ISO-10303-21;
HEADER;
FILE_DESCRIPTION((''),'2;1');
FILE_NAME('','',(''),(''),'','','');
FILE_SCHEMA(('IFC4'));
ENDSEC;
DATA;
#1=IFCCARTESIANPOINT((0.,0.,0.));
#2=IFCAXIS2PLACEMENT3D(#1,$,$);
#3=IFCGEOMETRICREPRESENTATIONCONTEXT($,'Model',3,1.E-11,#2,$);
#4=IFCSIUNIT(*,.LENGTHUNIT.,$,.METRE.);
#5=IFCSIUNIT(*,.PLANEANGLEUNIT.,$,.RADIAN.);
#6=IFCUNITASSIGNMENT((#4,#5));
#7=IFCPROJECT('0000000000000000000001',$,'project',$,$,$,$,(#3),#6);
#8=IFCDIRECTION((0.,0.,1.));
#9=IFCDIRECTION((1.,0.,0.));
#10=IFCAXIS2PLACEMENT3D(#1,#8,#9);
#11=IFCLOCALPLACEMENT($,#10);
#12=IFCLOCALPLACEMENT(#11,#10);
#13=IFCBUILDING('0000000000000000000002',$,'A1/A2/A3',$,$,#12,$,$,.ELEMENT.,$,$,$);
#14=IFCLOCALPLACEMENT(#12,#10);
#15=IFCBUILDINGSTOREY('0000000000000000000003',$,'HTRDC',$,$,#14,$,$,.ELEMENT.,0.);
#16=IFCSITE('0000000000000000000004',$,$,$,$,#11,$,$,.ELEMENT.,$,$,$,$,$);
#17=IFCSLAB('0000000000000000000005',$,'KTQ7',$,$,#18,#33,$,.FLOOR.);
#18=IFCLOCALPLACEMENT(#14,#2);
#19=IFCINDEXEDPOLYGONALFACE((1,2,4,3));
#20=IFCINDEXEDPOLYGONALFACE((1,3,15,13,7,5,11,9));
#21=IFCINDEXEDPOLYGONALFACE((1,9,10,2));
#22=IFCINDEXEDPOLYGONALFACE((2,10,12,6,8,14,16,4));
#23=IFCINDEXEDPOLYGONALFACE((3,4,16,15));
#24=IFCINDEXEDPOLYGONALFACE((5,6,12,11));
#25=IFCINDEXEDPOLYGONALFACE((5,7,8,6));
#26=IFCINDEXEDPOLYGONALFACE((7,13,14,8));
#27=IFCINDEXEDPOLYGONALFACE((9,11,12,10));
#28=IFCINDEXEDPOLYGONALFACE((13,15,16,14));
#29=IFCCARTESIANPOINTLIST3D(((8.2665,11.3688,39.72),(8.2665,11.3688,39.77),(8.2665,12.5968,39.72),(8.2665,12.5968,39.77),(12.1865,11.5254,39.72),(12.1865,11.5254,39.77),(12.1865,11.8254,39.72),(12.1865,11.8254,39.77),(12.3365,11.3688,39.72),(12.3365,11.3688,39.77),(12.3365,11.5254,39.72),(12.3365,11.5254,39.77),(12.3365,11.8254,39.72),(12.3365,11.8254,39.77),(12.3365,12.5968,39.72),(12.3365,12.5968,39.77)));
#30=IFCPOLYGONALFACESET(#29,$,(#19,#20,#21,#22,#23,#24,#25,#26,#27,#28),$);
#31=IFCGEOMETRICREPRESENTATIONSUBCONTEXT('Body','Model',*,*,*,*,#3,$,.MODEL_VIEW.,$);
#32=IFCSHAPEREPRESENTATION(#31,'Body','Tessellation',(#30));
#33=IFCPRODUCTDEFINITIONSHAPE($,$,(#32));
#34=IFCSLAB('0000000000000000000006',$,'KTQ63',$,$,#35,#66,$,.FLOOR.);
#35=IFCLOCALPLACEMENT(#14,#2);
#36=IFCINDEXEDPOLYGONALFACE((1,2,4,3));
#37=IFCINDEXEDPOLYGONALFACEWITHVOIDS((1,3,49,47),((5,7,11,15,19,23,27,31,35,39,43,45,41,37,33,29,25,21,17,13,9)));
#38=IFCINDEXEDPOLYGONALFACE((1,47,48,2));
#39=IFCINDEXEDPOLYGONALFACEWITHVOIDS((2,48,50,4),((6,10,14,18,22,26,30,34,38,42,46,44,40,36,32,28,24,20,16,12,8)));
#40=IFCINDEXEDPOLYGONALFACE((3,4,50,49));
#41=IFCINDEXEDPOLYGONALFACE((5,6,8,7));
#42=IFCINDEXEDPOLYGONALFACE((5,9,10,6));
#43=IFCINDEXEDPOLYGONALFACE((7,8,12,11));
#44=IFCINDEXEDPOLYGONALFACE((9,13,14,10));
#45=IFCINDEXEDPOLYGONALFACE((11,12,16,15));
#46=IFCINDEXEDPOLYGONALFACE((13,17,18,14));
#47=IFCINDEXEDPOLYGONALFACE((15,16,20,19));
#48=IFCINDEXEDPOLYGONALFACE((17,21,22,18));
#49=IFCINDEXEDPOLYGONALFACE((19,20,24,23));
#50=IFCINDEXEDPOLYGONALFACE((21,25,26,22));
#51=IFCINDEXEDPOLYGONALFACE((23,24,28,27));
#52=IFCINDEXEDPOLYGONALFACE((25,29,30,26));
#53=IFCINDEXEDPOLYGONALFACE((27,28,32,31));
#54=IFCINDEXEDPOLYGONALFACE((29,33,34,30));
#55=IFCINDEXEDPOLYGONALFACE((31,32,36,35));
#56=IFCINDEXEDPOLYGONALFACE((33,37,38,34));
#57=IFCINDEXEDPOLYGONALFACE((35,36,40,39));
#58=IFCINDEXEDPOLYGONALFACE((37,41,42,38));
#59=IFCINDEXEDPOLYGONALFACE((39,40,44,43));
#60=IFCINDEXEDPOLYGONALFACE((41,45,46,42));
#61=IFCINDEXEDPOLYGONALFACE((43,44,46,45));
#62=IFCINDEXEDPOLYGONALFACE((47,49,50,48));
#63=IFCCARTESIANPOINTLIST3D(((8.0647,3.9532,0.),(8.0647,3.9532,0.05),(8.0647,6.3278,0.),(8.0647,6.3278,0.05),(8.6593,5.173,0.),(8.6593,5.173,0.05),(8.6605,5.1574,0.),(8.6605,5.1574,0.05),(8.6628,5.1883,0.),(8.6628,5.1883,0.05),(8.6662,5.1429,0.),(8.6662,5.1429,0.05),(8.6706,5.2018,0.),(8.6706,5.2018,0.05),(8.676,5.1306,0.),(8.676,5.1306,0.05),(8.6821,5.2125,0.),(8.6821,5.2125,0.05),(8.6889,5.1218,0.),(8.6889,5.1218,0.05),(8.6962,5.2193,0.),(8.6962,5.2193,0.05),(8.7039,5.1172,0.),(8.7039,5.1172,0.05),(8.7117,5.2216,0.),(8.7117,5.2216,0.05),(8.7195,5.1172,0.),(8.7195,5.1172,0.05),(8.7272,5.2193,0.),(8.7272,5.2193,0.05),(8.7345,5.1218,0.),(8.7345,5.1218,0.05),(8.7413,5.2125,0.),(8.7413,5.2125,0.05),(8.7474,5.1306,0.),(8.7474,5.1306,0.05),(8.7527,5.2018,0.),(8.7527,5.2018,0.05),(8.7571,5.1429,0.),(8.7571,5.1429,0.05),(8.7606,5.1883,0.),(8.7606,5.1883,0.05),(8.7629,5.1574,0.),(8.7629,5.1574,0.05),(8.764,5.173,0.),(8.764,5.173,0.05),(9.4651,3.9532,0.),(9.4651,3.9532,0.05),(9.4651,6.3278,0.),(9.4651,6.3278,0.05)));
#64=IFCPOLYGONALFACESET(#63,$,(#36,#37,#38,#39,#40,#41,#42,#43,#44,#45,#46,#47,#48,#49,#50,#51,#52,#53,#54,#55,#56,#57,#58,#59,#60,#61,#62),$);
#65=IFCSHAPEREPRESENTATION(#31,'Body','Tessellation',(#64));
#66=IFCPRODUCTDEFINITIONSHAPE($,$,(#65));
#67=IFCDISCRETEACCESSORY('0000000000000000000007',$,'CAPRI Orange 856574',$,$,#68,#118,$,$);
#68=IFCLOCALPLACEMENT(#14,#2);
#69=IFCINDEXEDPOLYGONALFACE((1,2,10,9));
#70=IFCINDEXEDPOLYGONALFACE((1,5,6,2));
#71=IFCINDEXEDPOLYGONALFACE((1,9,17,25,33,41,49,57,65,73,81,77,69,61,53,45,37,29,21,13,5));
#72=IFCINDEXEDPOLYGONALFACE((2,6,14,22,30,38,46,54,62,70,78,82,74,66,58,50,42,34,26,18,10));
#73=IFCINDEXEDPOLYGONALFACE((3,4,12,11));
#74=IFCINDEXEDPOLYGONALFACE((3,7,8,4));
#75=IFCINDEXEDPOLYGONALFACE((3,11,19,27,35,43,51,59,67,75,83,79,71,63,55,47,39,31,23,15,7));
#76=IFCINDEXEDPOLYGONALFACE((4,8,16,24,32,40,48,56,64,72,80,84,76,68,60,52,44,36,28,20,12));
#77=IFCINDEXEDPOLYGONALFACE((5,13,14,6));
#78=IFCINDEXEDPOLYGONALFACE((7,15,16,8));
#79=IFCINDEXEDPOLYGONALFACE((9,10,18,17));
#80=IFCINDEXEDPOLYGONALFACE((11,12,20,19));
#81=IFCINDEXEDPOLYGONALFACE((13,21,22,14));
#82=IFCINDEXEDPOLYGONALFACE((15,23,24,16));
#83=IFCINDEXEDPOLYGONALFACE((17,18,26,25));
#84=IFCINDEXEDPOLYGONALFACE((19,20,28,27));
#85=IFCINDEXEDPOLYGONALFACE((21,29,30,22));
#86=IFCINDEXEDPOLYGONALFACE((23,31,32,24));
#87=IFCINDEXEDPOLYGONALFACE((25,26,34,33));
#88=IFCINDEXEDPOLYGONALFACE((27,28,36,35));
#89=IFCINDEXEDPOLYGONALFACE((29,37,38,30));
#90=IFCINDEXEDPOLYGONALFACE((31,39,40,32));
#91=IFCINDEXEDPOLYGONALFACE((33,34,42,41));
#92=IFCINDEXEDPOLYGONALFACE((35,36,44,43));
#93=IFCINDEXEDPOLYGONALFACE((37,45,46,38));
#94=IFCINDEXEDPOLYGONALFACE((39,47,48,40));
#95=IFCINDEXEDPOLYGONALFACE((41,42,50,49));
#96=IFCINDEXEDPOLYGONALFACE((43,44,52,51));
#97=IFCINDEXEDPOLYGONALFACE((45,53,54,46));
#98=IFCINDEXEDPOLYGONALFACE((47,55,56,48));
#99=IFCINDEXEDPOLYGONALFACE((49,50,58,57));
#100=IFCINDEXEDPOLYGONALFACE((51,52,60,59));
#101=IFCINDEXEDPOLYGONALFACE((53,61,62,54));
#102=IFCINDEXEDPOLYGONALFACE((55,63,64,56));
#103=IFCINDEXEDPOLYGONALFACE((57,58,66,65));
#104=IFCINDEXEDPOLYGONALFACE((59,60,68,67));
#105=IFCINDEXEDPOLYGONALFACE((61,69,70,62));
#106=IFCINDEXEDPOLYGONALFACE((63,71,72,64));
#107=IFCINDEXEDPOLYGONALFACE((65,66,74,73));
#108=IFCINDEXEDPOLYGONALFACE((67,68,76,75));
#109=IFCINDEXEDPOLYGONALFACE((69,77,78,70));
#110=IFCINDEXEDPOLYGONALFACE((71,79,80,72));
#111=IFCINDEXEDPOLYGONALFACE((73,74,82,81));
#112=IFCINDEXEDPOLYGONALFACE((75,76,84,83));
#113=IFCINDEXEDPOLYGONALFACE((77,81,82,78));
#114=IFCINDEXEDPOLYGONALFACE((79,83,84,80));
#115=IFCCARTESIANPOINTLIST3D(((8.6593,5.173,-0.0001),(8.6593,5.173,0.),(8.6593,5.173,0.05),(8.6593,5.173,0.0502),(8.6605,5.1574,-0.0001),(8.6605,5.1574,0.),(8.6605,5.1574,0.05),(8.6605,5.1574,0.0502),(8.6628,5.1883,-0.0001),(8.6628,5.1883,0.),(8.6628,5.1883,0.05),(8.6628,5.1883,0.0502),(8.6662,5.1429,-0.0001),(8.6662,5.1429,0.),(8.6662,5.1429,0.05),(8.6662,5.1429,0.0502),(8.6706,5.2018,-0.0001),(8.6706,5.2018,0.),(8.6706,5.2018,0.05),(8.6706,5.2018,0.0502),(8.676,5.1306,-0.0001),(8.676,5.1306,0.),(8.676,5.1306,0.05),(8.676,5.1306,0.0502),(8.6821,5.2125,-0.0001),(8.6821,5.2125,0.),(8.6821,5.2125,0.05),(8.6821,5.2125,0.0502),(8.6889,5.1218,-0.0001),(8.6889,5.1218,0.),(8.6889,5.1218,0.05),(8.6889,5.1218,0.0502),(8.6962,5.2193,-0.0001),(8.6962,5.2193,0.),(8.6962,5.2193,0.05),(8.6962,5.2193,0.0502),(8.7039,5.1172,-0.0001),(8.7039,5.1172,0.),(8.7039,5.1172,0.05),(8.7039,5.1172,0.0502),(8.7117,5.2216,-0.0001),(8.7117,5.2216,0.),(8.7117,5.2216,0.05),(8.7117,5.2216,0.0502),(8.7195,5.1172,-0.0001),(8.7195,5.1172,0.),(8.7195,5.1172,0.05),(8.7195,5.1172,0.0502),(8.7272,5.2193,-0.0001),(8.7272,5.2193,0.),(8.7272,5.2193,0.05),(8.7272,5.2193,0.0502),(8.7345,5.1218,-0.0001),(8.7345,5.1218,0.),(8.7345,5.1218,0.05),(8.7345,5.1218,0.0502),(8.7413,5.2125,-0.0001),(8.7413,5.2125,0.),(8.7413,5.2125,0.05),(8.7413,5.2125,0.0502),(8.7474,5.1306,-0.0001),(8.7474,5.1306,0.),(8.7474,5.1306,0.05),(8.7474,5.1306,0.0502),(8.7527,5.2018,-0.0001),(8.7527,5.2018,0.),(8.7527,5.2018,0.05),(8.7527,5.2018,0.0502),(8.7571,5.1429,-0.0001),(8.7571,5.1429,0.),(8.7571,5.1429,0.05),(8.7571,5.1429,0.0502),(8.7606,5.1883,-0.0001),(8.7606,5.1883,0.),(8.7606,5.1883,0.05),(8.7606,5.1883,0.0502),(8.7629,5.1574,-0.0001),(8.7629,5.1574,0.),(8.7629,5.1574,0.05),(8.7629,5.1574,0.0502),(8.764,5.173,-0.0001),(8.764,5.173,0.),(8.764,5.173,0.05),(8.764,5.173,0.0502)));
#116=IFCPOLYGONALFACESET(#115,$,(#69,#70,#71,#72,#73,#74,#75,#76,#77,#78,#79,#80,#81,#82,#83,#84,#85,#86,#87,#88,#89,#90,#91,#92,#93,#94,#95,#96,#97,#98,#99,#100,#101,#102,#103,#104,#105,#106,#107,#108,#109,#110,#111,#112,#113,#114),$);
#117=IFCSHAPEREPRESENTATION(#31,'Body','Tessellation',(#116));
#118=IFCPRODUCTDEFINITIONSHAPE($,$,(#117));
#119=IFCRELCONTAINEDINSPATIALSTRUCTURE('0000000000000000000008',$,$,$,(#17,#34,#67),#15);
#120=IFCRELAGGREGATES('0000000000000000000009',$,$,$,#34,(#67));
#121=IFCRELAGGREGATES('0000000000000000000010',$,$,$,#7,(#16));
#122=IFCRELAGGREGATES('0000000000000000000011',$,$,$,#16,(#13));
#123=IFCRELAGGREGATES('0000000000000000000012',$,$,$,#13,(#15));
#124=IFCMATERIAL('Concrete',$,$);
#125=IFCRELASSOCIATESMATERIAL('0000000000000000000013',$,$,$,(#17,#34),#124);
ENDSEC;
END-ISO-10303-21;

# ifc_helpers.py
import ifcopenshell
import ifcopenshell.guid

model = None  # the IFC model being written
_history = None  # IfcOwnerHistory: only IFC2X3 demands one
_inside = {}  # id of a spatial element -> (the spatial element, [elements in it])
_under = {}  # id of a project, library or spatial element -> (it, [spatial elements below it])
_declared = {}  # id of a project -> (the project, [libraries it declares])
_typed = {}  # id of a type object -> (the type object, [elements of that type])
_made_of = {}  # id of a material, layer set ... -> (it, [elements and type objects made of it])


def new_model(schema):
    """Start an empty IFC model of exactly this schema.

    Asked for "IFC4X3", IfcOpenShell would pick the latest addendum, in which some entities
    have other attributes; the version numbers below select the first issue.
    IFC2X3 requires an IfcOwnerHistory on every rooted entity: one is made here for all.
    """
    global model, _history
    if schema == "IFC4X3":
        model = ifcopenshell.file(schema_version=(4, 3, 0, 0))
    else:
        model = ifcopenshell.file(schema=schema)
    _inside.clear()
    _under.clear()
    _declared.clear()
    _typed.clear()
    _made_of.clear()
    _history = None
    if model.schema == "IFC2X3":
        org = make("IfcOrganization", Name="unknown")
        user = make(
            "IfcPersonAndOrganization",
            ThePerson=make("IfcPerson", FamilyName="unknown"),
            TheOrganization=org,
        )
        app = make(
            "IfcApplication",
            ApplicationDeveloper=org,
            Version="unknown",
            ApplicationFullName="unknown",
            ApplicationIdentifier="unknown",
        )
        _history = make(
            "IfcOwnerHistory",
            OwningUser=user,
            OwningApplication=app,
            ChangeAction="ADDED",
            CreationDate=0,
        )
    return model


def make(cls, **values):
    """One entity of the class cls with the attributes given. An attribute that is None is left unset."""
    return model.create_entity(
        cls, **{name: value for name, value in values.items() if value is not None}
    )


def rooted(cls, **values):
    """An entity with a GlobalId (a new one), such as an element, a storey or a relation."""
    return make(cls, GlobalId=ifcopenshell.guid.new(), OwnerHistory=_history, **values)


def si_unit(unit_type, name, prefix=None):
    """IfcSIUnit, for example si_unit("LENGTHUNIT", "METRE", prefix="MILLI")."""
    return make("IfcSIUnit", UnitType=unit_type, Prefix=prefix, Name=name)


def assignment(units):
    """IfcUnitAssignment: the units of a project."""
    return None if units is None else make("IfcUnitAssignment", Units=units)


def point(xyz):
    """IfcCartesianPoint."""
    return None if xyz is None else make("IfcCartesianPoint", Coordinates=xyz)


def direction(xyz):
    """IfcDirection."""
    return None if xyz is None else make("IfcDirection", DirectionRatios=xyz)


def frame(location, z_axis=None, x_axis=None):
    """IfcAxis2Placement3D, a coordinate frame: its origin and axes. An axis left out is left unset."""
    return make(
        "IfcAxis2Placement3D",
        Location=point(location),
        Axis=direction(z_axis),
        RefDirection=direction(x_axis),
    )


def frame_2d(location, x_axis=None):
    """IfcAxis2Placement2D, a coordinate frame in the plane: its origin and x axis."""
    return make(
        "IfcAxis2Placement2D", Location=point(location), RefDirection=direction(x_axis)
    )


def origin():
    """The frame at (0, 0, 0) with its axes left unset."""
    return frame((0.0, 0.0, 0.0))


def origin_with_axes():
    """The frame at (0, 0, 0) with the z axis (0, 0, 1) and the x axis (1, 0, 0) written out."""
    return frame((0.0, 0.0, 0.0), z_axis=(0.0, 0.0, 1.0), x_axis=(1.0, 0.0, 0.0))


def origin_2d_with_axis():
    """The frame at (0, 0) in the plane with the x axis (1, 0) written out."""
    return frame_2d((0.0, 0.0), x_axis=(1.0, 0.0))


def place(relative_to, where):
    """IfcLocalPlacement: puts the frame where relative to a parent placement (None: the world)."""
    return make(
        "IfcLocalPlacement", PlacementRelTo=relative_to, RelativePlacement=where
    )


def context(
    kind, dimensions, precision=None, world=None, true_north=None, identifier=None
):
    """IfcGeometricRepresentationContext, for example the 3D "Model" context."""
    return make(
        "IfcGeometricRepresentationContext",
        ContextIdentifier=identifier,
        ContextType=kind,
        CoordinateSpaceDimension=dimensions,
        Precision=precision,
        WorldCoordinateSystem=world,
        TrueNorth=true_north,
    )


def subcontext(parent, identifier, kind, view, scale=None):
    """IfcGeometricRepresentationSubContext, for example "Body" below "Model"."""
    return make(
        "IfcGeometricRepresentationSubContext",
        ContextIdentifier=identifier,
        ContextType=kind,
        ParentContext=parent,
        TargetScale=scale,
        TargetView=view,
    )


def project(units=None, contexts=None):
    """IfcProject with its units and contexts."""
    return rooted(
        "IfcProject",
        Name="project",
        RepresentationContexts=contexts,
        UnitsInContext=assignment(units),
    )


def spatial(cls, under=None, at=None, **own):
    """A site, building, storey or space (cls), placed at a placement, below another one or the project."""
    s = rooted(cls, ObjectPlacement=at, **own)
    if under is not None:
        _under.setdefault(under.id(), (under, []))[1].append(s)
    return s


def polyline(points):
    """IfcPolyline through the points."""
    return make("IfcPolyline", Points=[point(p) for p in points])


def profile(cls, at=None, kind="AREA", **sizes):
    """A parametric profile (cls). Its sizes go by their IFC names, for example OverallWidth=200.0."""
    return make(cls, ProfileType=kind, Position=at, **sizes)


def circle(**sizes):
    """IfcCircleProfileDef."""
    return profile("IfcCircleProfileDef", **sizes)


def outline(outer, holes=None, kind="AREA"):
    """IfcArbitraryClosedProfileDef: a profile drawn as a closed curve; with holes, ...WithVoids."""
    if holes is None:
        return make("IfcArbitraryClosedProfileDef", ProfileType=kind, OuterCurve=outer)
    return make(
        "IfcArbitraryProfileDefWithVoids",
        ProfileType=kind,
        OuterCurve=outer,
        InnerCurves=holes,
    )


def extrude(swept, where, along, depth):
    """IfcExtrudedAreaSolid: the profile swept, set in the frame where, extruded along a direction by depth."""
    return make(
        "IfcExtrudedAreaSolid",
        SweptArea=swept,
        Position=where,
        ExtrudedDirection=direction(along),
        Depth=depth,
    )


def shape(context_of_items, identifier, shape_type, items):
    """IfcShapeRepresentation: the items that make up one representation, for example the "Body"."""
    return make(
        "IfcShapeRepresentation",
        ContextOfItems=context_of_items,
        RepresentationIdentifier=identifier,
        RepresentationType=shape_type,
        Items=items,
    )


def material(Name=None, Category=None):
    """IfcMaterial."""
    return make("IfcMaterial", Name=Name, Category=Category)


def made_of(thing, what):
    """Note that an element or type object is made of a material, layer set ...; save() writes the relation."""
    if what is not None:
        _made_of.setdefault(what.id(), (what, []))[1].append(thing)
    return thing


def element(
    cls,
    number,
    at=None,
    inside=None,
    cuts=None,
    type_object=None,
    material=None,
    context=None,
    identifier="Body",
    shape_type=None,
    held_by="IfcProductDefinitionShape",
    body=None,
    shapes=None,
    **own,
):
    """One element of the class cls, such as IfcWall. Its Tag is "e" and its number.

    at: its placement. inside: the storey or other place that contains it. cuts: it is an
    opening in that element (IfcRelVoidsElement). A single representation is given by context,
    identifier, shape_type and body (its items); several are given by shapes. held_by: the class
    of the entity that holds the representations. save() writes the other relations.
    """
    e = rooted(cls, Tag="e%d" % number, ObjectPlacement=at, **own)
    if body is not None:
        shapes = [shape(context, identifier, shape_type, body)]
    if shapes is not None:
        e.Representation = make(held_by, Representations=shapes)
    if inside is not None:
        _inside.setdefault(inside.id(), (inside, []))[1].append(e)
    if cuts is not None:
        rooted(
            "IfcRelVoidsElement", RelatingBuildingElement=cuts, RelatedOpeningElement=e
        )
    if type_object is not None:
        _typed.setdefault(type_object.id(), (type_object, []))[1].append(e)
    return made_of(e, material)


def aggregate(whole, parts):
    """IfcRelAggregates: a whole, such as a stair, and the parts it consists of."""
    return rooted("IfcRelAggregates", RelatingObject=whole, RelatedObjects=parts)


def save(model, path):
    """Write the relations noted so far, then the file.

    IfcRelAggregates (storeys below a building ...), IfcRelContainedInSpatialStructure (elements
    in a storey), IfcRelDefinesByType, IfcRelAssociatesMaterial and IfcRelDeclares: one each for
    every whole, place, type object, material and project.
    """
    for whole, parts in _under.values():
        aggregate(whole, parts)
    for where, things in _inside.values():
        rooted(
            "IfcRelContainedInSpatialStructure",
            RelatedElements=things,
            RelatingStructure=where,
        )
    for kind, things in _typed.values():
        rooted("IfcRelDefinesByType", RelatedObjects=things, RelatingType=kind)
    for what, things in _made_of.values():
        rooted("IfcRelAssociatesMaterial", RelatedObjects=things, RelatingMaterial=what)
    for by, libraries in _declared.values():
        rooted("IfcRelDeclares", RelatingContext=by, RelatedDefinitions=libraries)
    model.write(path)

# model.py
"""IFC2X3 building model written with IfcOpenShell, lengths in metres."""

from ifc_helpers import new_model, si_unit, frame, frame_2d, origin, origin_with_axes, origin_2d_with_axis, place, context, subcontext, project, spatial, polyline, circle, outline, extrude, material, element, aggregate, save


model = new_model("IFC2X3")

# Units and contexts
model_context = context("Model", 3, precision=1e-11, world=origin())
body_context = subcontext(model_context, "Body", "Model", "MODEL_VIEW")
ifc_project = project(units=[si_unit("LENGTHUNIT", "METRE"), si_unit("PLANEANGLEUNIT", "RADIAN")], contexts=[model_context])

# Site, building, storey
site_placement = place(None, origin_with_axes())
site = spatial("IfcSite", under=ifc_project, at=site_placement, CompositionType="ELEMENT")
building_placement = place(site_placement, origin_with_axes())
building = spatial("IfcBuilding", under=site, at=building_placement, Name="A1/A2/A3", CompositionType="ELEMENT")
storey_placement = place(building_placement, origin_with_axes())
storey = spatial("IfcBuildingStorey", under=building, at=storey_placement, Name="HTRDC", CompositionType="ELEMENT", Elevation=0.0)

# Slab, opening
ifc_material = material(Name="Concrete")
slab_1_placement = place(storey_placement, frame((8.2665, 11.3688, 39.72), z_axis=(0.0, 0.0, 1.0), x_axis=(1.0, 0.0, 0.0)))
slab_1 = element("IfcSlab", 1, at=slab_1_placement, inside=storey, material=ifc_material, Name="KTQ7", PredefinedType="FLOOR", context=body_context, shape_type="SweptSolid", body=[
    extrude(outline(polyline([(0.0, 0.0), (0.0, -4.07), (1.228, -4.07), (1.228, 0.0), (0.0, 0.0)])), frame((0.0, 0.0, 0.0), z_axis=(0.0, 0.0, 1.0), x_axis=(0.0, 1.0, 0.0)), (0.0, 0.0, 1.0), 0.05),
])
opening_1_placement = place(slab_1_placement, origin_with_axes())
element("IfcOpeningElement", 2, at=opening_1_placement, cuts=slab_1, ObjectType="Opening", context=body_context, shape_type="SweptSolid", body=[
    extrude(outline(polyline([(0.1566, -3.92), (0.1566, -4.07), (0.4566, -4.07), (0.4566, -3.92), (0.1566, -3.92)])), frame((0.0, 0.0, 0.0), z_axis=(0.0, 0.0, 1.0), x_axis=(0.0, 1.0, 0.0)), (0.0, 0.0, 1.0), 0.05),
])

# Slab, opening
slab_2_placement = place(storey_placement, frame((8.0647, 3.9532, 0.0), z_axis=(0.0, 0.0, 1.0), x_axis=(1.0, 0.0, 0.0)))
slab_2 = element("IfcSlab", 3, at=slab_2_placement, inside=storey, material=ifc_material, Name="KTQ63", PredefinedType="FLOOR", context=body_context, shape_type="SweptSolid", body=[
    extrude(outline(polyline([(0.0, 0.0), (0.0, -1.4003), (2.3746, -1.4003), (2.3746, 0.0), (0.0, 0.0)])), frame((0.0, 0.0, 0.0), z_axis=(0.0, 0.0, 1.0), x_axis=(0.0, 1.0, 0.0)), (0.0, 0.0, 1.0), 0.05),
])
opening_2_placement = place(slab_2_placement, frame((0.6469, 1.2159, 0.0), z_axis=(0.0, 0.0, 1.0), x_axis=(1.0, 0.0, 0.0)))
element("IfcOpeningElement", 4, at=opening_2_placement, cuts=slab_2, ObjectType="Opening", context=body_context, shape_type="SweptSolid", body=[
    extrude(circle(Radius=0.0525, at=origin_2d_with_axis()), frame((0.0, 0.0, 0.0), z_axis=(0.0, 0.0, 1.0), x_axis=(0.0, 1.0, 0.0)), (0.0, 0.0, 1.0), 0.05),
])

# Discrete accessory
discrete_accessory_1_placement = place(storey_placement, frame((8.0647, 3.9532, -0.0001), z_axis=(0.0, 0.0, 1.0), x_axis=(1.0, 0.0, 0.0)))
discrete_accessory_1 = element("IfcDiscreteAccessory", 5, at=discrete_accessory_1_placement, inside=storey, Name="CAPRI Orange 856574", context=body_context, shape_type="SweptSolid", body=[
    extrude(circle(Radius=0.0525, at=frame_2d((1.2159, -0.6469), x_axis=(1.0, 0.0))), frame((0.0, 0.0, 0.0), z_axis=(0.0, 0.0, 1.0), x_axis=(0.0, 1.0, 0.0)), (0.0, 0.0, 1.0), 0.0503),
])
aggregate(slab_2, [discrete_accessory_1])

save(model, "model.ifc")
